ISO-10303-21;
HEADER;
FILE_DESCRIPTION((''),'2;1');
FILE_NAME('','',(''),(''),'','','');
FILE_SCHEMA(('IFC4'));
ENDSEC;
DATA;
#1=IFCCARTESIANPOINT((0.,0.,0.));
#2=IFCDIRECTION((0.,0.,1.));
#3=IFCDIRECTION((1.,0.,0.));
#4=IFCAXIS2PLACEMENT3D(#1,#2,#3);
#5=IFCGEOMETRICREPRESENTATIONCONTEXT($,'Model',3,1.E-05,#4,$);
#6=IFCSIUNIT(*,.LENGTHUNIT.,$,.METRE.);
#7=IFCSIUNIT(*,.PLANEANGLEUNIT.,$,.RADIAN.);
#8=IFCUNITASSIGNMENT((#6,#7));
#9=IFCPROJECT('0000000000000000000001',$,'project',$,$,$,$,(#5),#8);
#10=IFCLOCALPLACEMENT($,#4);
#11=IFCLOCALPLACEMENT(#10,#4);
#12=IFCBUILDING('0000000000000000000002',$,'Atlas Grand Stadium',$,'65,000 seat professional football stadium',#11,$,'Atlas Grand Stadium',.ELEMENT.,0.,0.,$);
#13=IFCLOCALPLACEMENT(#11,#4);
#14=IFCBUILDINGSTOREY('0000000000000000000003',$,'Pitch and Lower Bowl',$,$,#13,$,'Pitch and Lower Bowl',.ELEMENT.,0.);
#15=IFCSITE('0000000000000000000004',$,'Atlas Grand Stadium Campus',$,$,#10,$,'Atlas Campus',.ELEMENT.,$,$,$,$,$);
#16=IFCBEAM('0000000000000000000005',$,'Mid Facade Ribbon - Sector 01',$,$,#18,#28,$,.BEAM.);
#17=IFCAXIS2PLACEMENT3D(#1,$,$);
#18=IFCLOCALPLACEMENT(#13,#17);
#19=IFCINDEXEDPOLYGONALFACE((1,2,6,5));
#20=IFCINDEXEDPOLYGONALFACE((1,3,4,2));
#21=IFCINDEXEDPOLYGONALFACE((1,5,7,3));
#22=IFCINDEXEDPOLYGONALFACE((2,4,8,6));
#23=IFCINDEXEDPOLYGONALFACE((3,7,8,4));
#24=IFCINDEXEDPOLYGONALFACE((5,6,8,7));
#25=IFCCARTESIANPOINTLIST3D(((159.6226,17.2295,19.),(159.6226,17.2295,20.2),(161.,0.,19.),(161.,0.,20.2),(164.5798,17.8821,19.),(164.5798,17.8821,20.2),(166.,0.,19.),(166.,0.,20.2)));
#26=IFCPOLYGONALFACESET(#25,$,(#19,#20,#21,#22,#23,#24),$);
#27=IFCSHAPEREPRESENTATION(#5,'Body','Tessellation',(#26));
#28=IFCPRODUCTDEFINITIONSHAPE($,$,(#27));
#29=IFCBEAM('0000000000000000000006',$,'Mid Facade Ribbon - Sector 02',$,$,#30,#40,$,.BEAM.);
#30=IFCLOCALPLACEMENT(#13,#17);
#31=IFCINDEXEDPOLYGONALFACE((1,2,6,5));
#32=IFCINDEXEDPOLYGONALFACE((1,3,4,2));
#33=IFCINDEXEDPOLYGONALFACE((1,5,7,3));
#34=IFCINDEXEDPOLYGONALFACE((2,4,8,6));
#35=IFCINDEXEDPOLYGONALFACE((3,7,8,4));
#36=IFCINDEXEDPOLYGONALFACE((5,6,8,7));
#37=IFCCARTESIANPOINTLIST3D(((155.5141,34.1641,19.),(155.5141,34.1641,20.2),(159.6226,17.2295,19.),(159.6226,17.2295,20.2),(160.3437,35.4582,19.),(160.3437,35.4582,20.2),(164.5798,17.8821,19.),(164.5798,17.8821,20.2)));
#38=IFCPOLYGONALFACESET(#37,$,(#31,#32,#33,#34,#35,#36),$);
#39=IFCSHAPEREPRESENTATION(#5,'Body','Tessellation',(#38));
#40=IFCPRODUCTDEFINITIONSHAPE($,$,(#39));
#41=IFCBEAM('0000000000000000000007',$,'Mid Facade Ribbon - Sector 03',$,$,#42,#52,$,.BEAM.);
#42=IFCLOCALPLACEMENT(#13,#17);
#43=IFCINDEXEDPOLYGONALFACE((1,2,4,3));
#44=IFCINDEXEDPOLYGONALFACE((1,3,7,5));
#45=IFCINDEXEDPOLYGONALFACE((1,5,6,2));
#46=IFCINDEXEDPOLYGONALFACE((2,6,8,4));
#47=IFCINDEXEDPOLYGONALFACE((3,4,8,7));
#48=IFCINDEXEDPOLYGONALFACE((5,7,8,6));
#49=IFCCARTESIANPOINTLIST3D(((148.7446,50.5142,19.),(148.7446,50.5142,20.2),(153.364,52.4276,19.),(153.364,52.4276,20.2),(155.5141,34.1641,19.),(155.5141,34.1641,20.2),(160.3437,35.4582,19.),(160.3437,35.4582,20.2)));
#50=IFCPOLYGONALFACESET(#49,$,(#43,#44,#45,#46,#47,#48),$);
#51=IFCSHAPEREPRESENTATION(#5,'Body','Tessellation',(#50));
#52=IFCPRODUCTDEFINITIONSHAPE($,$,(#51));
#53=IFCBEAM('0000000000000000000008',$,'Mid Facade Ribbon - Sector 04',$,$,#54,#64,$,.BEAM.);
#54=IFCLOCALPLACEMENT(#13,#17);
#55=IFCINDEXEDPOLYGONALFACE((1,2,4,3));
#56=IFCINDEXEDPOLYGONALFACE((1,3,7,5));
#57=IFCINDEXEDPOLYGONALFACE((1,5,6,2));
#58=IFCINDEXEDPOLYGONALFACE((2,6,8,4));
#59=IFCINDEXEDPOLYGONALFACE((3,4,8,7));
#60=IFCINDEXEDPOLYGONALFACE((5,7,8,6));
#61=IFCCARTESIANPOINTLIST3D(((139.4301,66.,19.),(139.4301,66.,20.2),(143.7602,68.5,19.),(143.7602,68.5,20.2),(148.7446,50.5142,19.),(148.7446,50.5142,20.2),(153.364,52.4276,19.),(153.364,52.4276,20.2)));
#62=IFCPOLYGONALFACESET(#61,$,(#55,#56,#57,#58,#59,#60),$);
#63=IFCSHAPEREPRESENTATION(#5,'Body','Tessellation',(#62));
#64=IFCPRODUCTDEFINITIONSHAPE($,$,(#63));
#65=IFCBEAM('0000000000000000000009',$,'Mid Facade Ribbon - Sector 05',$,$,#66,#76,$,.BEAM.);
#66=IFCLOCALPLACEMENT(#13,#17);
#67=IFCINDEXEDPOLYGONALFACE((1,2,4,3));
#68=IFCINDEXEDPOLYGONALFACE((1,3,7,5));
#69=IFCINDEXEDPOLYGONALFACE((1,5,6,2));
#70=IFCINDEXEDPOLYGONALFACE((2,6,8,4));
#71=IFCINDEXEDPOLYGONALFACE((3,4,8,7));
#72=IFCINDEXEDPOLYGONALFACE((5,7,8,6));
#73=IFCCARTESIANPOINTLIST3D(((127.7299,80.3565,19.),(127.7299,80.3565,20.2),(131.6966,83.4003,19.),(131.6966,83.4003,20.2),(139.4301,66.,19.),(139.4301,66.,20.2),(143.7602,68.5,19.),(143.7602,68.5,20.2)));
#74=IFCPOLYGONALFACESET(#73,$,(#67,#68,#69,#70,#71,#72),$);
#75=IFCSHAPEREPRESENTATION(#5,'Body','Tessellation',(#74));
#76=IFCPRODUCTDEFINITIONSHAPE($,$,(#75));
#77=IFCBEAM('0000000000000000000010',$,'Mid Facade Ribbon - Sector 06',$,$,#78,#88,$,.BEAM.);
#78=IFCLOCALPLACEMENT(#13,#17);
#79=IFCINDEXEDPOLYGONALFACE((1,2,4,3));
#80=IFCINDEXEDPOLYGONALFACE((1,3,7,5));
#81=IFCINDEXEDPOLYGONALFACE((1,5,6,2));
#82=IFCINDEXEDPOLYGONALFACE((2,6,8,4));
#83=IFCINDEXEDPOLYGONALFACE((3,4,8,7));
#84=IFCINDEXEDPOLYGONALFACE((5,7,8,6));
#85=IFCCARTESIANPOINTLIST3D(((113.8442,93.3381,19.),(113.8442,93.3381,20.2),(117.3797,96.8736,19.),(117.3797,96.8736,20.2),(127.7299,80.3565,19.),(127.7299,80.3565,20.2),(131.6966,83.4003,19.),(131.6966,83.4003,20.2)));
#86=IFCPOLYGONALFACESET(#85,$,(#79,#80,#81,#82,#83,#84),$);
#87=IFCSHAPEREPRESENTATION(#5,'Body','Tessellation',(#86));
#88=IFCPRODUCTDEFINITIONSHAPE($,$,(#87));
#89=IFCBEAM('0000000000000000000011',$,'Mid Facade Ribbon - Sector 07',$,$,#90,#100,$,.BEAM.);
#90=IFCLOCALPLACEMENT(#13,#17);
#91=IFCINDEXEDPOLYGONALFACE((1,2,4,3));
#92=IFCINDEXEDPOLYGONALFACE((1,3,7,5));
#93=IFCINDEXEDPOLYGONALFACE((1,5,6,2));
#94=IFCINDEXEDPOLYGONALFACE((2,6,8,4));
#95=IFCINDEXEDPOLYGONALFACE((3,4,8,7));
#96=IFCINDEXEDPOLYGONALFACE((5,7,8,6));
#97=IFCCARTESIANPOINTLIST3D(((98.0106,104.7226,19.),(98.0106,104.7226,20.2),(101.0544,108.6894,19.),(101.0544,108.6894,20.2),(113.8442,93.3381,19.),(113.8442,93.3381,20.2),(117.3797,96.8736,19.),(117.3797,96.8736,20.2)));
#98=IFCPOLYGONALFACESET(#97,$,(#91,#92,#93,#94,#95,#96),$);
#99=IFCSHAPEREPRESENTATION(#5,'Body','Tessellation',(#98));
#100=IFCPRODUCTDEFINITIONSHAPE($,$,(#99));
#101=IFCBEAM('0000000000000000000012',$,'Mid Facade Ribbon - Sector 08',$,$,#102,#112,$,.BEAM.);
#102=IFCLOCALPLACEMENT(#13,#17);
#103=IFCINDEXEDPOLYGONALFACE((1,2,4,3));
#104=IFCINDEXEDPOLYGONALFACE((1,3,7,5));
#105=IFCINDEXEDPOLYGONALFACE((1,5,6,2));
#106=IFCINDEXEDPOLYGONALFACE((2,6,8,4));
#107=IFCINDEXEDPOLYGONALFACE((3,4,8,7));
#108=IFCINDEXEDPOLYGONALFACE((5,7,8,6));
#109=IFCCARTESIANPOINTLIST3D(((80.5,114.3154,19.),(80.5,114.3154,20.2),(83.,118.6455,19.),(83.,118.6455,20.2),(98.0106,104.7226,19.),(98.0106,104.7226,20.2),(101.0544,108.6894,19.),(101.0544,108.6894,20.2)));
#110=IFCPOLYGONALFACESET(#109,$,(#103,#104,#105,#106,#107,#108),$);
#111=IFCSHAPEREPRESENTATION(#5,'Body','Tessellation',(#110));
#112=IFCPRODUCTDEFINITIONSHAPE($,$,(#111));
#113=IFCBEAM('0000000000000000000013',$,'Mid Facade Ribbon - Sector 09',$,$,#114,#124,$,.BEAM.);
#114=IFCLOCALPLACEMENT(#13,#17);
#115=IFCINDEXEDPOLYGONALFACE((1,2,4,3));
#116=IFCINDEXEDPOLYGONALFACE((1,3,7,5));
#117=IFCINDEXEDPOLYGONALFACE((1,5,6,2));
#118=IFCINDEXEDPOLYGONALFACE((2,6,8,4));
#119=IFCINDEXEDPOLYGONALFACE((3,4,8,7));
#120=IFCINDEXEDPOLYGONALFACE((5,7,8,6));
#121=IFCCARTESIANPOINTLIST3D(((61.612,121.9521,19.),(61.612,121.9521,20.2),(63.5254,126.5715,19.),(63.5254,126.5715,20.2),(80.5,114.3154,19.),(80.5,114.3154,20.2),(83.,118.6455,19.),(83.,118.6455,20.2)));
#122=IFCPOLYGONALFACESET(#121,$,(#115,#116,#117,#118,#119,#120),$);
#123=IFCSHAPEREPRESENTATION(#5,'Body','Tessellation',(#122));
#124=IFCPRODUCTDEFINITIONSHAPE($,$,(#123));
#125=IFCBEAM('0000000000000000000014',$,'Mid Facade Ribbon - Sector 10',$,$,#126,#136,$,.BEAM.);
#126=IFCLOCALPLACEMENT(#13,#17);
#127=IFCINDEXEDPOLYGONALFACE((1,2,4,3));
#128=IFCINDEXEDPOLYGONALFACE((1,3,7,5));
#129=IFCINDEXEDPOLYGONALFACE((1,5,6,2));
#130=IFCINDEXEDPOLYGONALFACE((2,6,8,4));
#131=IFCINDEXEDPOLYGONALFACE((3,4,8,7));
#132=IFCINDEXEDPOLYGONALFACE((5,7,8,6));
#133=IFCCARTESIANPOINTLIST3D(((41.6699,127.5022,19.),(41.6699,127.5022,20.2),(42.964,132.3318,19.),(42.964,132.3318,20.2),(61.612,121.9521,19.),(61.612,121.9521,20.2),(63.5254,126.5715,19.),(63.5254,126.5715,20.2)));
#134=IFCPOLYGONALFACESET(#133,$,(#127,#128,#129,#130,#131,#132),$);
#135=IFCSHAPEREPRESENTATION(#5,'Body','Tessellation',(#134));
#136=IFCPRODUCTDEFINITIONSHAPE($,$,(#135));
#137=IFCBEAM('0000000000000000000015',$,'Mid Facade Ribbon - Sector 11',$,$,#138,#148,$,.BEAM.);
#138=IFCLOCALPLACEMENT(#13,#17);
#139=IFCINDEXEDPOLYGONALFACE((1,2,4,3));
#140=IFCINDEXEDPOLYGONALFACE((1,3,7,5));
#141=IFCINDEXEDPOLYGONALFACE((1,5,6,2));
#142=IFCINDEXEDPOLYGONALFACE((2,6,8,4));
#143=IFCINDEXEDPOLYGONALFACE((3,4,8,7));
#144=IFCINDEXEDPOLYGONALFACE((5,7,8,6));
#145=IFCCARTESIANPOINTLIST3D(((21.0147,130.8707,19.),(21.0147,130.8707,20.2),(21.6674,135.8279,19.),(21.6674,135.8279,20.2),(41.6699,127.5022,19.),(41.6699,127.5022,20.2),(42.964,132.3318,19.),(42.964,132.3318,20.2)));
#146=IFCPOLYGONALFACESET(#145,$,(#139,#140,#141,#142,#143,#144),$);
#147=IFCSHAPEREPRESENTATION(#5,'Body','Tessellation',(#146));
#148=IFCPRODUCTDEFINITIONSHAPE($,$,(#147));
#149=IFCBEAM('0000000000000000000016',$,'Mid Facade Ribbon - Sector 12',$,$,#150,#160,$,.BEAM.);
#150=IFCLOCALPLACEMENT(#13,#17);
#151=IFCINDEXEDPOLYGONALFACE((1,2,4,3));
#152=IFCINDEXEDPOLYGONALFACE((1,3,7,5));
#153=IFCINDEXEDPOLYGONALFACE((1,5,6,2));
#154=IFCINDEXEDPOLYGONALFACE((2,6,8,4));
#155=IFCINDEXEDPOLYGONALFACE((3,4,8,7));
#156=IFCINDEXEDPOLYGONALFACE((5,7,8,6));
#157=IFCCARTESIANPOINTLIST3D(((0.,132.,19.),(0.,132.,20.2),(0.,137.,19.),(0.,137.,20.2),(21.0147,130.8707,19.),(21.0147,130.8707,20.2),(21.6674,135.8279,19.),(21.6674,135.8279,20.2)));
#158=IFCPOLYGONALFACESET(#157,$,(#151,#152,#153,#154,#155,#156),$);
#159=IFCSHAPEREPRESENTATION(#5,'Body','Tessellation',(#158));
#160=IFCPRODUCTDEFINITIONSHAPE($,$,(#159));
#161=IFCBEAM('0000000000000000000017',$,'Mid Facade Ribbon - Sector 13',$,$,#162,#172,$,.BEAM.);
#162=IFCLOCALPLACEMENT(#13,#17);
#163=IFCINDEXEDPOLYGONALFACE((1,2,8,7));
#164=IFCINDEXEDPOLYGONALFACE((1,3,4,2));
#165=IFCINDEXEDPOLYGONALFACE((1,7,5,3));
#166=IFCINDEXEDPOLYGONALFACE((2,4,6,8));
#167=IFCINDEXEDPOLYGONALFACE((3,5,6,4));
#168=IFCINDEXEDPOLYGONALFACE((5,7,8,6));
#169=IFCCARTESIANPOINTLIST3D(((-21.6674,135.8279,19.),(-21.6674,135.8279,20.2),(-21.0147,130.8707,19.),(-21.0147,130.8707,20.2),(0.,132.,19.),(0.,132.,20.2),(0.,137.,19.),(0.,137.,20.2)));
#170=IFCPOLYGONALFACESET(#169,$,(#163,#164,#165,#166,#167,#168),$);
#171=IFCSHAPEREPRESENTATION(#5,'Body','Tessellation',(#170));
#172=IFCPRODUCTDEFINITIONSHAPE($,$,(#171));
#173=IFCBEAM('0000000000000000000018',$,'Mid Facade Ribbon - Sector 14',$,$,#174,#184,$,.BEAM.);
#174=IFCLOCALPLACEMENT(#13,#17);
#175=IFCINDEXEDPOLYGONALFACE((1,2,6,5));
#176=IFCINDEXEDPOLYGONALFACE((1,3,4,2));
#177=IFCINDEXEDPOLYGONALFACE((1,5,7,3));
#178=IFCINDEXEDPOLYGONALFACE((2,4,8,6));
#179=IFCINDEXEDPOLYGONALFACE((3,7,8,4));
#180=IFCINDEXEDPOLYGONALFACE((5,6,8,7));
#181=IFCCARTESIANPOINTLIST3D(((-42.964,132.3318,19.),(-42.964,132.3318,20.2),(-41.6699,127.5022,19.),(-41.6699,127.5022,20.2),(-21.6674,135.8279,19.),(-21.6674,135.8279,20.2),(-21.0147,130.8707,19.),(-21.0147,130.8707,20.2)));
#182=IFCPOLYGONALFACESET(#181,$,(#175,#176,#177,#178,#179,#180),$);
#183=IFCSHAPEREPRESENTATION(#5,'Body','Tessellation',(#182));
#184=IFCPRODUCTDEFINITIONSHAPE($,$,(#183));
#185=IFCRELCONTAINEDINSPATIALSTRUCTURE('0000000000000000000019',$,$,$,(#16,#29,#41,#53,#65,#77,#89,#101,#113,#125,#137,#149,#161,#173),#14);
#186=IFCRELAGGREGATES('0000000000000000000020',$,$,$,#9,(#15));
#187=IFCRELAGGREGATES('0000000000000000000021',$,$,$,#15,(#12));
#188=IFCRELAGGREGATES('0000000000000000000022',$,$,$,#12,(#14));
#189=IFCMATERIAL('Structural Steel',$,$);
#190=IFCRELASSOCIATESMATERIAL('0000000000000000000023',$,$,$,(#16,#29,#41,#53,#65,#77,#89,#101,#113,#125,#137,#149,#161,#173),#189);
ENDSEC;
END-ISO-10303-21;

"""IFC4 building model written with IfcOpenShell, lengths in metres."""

from ifc_helpers import new_model, si_unit, frame, origin_with_axes, place, context, project, spatial, polyline, outline, extrude, material, element, save


model = new_model("IFC4")

# Units and contexts
model_context = context("Model", 3, precision=1e-05, world=origin_with_axes())
ifc_project = project(units=[si_unit("LENGTHUNIT", "METRE"), si_unit("PLANEANGLEUNIT", "RADIAN")], contexts=[model_context])

# Site, building, storey
site_placement = place(None, origin_with_axes())
site = spatial("IfcSite", under=ifc_project, at=site_placement, Name="Atlas Grand Stadium Campus", LongName="Atlas Campus", CompositionType="ELEMENT")
building_placement = place(site_placement, origin_with_axes())
building = spatial("IfcBuilding", under=site, at=building_placement, Name="Atlas Grand Stadium", ObjectType="65,000 seat professional football stadium", LongName="Atlas Grand Stadium", CompositionType="ELEMENT", ElevationOfRefHeight=0.0, ElevationOfTerrain=0.0)
storey_placement = place(building_placement, origin_with_axes())
storey = spatial("IfcBuildingStorey", under=building, at=storey_placement, Name="Pitch and Lower Bowl", LongName="Pitch and Lower Bowl", CompositionType="ELEMENT", Elevation=0.0)

# Beams
ifc_material_1 = material(Name="Structural Steel")
beam_1_placement = place(storey_placement, frame((0.0, 0.0, 19.0), z_axis=(0.0, 0.0, 1.0), x_axis=(1.0, 0.0, 0.0)))
element("IfcBeam", 1, at=beam_1_placement, inside=storey, material=ifc_material_1, Name="Mid Facade Ribbon - Sector 01", PredefinedType="BEAM", context=model_context, shape_type="SweptSolid", body=[
    extrude(outline(polyline([(166.0, 0.0), (164.5798, 17.8821), (159.6226, 17.2295), (161.0, 0.0), (166.0, 0.0)])), origin_with_axes(), (0.0, 0.0, 1.0), 1.2),
])
beam_2_placement = place(storey_placement, frame((0.0, 0.0, 19.0), z_axis=(0.0, 0.0, 1.0), x_axis=(1.0, 0.0, 0.0)))
element("IfcBeam", 2, at=beam_2_placement, inside=storey, material=ifc_material_1, Name="Mid Facade Ribbon - Sector 02", PredefinedType="BEAM", context=model_context, shape_type="SweptSolid", body=[
    extrude(outline(polyline([(164.5798, 17.8821), (160.3437, 35.4582), (155.5141, 34.1641), (159.6226, 17.2295), (164.5798, 17.8821)])), origin_with_axes(), (0.0, 0.0, 1.0), 1.2),
])
beam_3_placement = place(storey_placement, frame((0.0, 0.0, 19.0), z_axis=(0.0, 0.0, 1.0), x_axis=(1.0, 0.0, 0.0)))
element("IfcBeam", 3, at=beam_3_placement, inside=storey, material=ifc_material_1, Name="Mid Facade Ribbon - Sector 03", PredefinedType="BEAM", context=model_context, shape_type="SweptSolid", body=[
    extrude(outline(polyline([(160.3437, 35.4582), (153.364, 52.4276), (148.7446, 50.5142), (155.5141, 34.1641), (160.3437, 35.4582)])), origin_with_axes(), (0.0, 0.0, 1.0), 1.2),
])
beam_4_placement = place(storey_placement, frame((0.0, 0.0, 19.0), z_axis=(0.0, 0.0, 1.0), x_axis=(1.0, 0.0, 0.0)))
element("IfcBeam", 4, at=beam_4_placement, inside=storey, material=ifc_material_1, Name="Mid Facade Ribbon - Sector 04", PredefinedType="BEAM", context=model_context, shape_type="SweptSolid", body=[
    extrude(outline(polyline([(153.364, 52.4276), (143.7602, 68.5), (139.4301, 66.0), (148.7446, 50.5142), (153.364, 52.4276)])), origin_with_axes(), (0.0, 0.0, 1.0), 1.2),
])
beam_5_placement = place(storey_placement, frame((0.0, 0.0, 19.0), z_axis=(0.0, 0.0, 1.0), x_axis=(1.0, 0.0, 0.0)))
element("IfcBeam", 5, at=beam_5_placement, inside=storey, material=ifc_material_1, Name="Mid Facade Ribbon - Sector 05", PredefinedType="BEAM", context=model_context, shape_type="SweptSolid", body=[
    extrude(outline(polyline([(143.7602, 68.5), (131.6967, 83.4003), (127.7299, 80.3565), (139.4301, 66.0), (143.7602, 68.5)])), origin_with_axes(), (0.0, 0.0, 1.0), 1.2),
])
beam_6_placement = place(storey_placement, frame((0.0, 0.0, 19.0), z_axis=(0.0, 0.0, 1.0), x_axis=(1.0, 0.0, 0.0)))
element("IfcBeam", 6, at=beam_6_placement, inside=storey, material=ifc_material_1, Name="Mid Facade Ribbon - Sector 06", PredefinedType="BEAM", context=model_context, shape_type="SweptSolid", body=[
    extrude(outline(polyline([(131.6967, 83.4003), (117.3797, 96.8736), (113.8442, 93.3381), (127.7299, 80.3565), (131.6967, 83.4003)])), origin_with_axes(), (0.0, 0.0, 1.0), 1.2),
])
beam_7_placement = place(storey_placement, frame((0.0, 0.0, 19.0), z_axis=(0.0, 0.0, 1.0), x_axis=(1.0, 0.0, 0.0)))
element("IfcBeam", 7, at=beam_7_placement, inside=storey, material=ifc_material_1, Name="Mid Facade Ribbon - Sector 07", PredefinedType="BEAM", context=model_context, shape_type="SweptSolid", body=[
    extrude(outline(polyline([(117.3797, 96.8736), (101.0544, 108.6894), (98.0106, 104.7226), (113.8442, 93.3381), (117.3797, 96.8736)])), origin_with_axes(), (0.0, 0.0, 1.0), 1.2),
])
beam_8_placement = place(storey_placement, frame((0.0, 0.0, 19.0), z_axis=(0.0, 0.0, 1.0), x_axis=(1.0, 0.0, 0.0)))
element("IfcBeam", 8, at=beam_8_placement, inside=storey, material=ifc_material_1, Name="Mid Facade Ribbon - Sector 08", PredefinedType="BEAM", context=model_context, shape_type="SweptSolid", body=[
    extrude(outline(polyline([(101.0544, 108.6894), (83.0, 118.6455), (80.5, 114.3153), (98.0106, 104.7226), (101.0544, 108.6894)])), origin_with_axes(), (0.0, 0.0, 1.0), 1.2),
])
beam_9_placement = place(storey_placement, frame((0.0, 0.0, 19.0), z_axis=(0.0, 0.0, 1.0), x_axis=(1.0, 0.0, 0.0)))
element("IfcBeam", 9, at=beam_9_placement, inside=storey, material=ifc_material_1, Name="Mid Facade Ribbon - Sector 09", PredefinedType="BEAM", context=model_context, shape_type="SweptSolid", body=[
    extrude(outline(polyline([(83.0, 118.6455), (63.5254, 126.5715), (61.612, 121.9521), (80.5, 114.3153), (83.0, 118.6455)])), origin_with_axes(), (0.0, 0.0, 1.0), 1.2),
])
beam_10_placement = place(storey_placement, frame((0.0, 0.0, 19.0), z_axis=(0.0, 0.0, 1.0), x_axis=(1.0, 0.0, 0.0)))
element("IfcBeam", 10, at=beam_10_placement, inside=storey, material=ifc_material_1, Name="Mid Facade Ribbon - Sector 10", PredefinedType="BEAM", context=model_context, shape_type="SweptSolid", body=[
    extrude(outline(polyline([(63.5254, 126.5715), (42.964, 132.3318), (41.6699, 127.5022), (61.612, 121.9521), (63.5254, 126.5715)])), origin_with_axes(), (0.0, 0.0, 1.0), 1.2),
])
beam_11_placement = place(storey_placement, frame((0.0, 0.0, 19.0), z_axis=(0.0, 0.0, 1.0), x_axis=(1.0, 0.0, 0.0)))
element("IfcBeam", 11, at=beam_11_placement, inside=storey, material=ifc_material_1, Name="Mid Facade Ribbon - Sector 11", PredefinedType="BEAM", context=model_context, shape_type="SweptSolid", body=[
    extrude(outline(polyline([(42.964, 132.3318), (21.6673, 135.8279), (21.0147, 130.8707), (41.6699, 127.5022), (42.964, 132.3318)])), origin_with_axes(), (0.0, 0.0, 1.0), 1.2),
])
beam_12_placement = place(storey_placement, frame((0.0, 0.0, 19.0), z_axis=(0.0, 0.0, 1.0), x_axis=(1.0, 0.0, 0.0)))
element("IfcBeam", 12, at=beam_12_placement, inside=storey, material=ifc_material_1, Name="Mid Facade Ribbon - Sector 12", PredefinedType="BEAM", context=model_context, shape_type="SweptSolid", body=[
    extrude(outline(polyline([(21.6673, 135.8279), (0.0, 137.0), (0.0, 132.0), (21.0147, 130.8707), (21.6673, 135.8279)])), origin_with_axes(), (0.0, 0.0, 1.0), 1.2),
])
beam_13_placement = place(storey_placement, frame((0.0, 0.0, 19.0), z_axis=(0.0, 0.0, 1.0), x_axis=(1.0, 0.0, 0.0)))
element("IfcBeam", 13, at=beam_13_placement, inside=storey, material=ifc_material_1, Name="Mid Facade Ribbon - Sector 13", PredefinedType="BEAM", context=model_context, shape_type="SweptSolid", body=[
    extrude(outline(polyline([(0.0, 137.0), (-21.6673, 135.8279), (-21.0147, 130.8707), (0.0, 132.0), (0.0, 137.0)])), origin_with_axes(), (0.0, 0.0, 1.0), 1.2),
])
beam_14_placement = place(storey_placement, frame((0.0, 0.0, 19.0), z_axis=(0.0, 0.0, 1.0), x_axis=(1.0, 0.0, 0.0)))
element("IfcBeam", 14, at=beam_14_placement, inside=storey, material=ifc_material_1, Name="Mid Facade Ribbon - Sector 14", PredefinedType="BEAM", context=model_context, shape_type="SweptSolid", body=[
    extrude(outline(polyline([(-21.6673, 135.8279), (-42.964, 132.3318), (-41.6699, 127.5022), (-21.0147, 130.8707), (-21.6673, 135.8279)])), origin_with_axes(), (0.0, 0.0, 1.0), 1.2),
])

save(model, "model.ifc")
